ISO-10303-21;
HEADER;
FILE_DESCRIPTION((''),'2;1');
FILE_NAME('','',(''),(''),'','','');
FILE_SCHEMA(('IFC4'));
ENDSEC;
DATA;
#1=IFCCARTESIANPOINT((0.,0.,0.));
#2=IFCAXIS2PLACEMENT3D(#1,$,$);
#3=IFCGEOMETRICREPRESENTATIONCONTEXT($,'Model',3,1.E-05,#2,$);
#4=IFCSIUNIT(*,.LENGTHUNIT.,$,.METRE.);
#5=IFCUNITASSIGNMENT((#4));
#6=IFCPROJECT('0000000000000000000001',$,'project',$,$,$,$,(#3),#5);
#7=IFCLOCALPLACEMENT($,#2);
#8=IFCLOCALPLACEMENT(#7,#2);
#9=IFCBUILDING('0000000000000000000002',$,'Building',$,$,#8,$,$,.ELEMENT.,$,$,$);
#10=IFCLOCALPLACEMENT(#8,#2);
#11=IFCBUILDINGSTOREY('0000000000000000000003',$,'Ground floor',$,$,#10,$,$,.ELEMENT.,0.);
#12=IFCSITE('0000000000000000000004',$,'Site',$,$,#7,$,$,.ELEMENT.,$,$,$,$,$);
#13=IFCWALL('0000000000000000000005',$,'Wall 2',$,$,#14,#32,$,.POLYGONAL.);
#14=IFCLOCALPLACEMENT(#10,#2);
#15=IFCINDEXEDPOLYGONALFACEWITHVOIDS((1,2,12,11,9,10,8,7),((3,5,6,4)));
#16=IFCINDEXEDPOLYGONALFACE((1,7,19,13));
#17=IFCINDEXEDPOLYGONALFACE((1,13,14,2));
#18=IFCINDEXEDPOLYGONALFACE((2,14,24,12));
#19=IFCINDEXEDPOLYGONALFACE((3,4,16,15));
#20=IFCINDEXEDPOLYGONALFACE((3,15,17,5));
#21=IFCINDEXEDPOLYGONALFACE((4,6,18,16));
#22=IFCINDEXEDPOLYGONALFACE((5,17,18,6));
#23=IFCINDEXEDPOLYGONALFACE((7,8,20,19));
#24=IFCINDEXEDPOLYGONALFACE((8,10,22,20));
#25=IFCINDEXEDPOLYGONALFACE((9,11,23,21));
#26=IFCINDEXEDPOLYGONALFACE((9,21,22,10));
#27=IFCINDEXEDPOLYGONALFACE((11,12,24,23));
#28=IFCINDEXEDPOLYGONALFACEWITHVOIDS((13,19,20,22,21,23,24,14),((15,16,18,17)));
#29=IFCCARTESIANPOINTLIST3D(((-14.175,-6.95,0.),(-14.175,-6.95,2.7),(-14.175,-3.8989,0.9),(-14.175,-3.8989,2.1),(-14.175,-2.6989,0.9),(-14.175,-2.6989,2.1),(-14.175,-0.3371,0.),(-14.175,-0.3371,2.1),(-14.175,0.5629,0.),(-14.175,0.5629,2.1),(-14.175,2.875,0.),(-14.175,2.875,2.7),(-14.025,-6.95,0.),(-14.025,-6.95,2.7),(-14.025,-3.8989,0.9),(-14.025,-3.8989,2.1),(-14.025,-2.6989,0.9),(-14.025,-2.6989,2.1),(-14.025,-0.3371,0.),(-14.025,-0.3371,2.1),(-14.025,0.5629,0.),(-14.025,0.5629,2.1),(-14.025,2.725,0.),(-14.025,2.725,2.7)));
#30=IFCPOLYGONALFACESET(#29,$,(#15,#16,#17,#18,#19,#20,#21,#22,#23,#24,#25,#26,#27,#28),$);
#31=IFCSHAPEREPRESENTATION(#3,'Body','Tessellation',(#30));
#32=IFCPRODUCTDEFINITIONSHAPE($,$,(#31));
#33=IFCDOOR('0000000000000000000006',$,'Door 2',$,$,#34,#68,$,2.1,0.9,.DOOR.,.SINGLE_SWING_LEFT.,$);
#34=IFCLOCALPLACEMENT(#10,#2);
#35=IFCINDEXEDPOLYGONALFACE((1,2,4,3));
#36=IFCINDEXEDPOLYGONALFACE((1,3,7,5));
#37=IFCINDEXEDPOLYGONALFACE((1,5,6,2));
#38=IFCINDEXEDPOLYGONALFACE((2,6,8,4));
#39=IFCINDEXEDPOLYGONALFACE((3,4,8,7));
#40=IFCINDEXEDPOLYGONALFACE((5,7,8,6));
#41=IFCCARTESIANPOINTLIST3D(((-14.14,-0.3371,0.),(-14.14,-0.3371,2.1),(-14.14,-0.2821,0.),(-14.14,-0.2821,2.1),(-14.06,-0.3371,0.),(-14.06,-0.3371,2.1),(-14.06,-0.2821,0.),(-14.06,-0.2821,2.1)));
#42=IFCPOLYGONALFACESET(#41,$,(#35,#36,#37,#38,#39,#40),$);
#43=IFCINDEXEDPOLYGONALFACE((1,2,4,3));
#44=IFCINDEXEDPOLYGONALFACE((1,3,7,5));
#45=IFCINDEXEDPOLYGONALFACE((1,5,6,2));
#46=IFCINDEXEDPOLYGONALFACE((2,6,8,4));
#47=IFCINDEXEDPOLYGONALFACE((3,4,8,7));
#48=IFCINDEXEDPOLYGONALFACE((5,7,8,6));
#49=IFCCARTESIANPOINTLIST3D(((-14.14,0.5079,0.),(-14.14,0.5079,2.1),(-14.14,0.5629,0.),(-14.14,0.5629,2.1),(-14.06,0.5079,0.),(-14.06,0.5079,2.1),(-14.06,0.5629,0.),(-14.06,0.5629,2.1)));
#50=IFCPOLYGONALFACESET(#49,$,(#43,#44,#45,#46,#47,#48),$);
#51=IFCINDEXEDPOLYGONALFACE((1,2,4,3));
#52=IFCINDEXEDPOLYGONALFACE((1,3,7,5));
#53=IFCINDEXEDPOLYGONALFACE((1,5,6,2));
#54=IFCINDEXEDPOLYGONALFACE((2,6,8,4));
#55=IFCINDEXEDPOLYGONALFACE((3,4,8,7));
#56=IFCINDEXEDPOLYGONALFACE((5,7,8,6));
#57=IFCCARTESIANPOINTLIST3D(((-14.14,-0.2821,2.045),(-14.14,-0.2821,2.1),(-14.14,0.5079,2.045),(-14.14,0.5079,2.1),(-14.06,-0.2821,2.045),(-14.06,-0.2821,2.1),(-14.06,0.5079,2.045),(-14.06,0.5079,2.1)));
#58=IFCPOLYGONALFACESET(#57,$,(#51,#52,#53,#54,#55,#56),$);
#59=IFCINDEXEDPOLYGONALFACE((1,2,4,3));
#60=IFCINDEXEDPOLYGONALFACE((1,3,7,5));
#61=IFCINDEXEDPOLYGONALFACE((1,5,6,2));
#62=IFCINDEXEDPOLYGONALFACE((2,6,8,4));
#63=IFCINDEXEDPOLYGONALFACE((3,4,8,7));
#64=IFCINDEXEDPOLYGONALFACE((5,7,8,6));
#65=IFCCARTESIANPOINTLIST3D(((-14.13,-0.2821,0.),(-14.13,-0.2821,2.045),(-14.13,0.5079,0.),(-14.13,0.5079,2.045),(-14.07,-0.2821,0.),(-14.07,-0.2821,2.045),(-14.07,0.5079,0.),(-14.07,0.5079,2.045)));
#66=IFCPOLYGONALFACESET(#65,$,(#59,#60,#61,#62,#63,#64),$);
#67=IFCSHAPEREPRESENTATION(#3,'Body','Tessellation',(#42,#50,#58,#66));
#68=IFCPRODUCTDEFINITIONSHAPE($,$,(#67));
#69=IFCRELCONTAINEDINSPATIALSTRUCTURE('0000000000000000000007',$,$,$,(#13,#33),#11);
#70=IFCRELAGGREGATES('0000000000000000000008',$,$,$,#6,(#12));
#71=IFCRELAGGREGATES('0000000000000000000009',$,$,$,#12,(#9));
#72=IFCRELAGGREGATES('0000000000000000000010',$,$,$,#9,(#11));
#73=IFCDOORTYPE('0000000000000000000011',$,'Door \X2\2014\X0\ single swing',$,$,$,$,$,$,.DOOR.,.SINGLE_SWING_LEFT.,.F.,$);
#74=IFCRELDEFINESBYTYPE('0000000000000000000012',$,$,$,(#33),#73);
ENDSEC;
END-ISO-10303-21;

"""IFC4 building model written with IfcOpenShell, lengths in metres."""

from ifc_helpers import new_model, si_unit, frame, frame_2d, origin, origin_with_axes, place, context, project, spatial, polyline, rectangle, outline, extrude, type_object, element, fill, save


model = new_model("IFC4")

# Units and contexts
model_context = context("Model", 3, precision=1e-05, world=origin())
ifc_project = project(units=[si_unit("LENGTHUNIT", "METRE")], contexts=[model_context])

# Site, building, storey
site_placement = place(None, origin())
site = spatial("IfcSite", under=ifc_project, at=site_placement, Name="Site", CompositionType="ELEMENT")
building_placement = place(site_placement, origin())
building = spatial("IfcBuilding", under=site, at=building_placement, Name="Building", CompositionType="ELEMENT")
storey_placement = place(building_placement, origin())
storey = spatial("IfcBuildingStorey", under=building, at=storey_placement, Name="Ground floor", CompositionType="ELEMENT", Elevation=0.0)

# Shared definitions
door_type = type_object("IfcDoorType", Name="Door — single swing", OperationType="SINGLE_SWING_LEFT", ParameterTakesPrecedence=False, PredefinedType="DOOR")

# Wall, openings, door
wall_1_placement = place(storey_placement, origin_with_axes())
wall_1 = element("IfcWall", 1, at=wall_1_placement, inside=storey, Name="Wall 2", PredefinedType="POLYGONAL", context=model_context, shape_type="SweptSolid", body=[
    extrude(outline(polyline([(-14.175, -6.95), (-14.025, -6.95), (-14.025, 2.725), (-14.175, 2.875), (-14.175, -6.95)])), origin(), (0.0, 0.0, 1.0), 2.7),
])
opening_1_placement = place(storey_placement, frame((-14.1, -3.8989, 0.9), z_axis=(0.0, 0.0, 1.0), x_axis=(0.0, 1.0, 0.0)))
element("IfcOpeningElement", 2, at=opening_1_placement, cuts=wall_1, PredefinedType="OPENING", context=model_context, shape_type="SweptSolid", body=[
    extrude(rectangle(XDim=1.2, YDim=0.21, at=frame_2d((0.6, 0.0))), origin(), (0.0, 0.0, 1.0), 1.2),
])
opening_2_placement = place(storey_placement, frame((-14.1, -0.3371, 0.0), z_axis=(0.0, 0.0, 1.0), x_axis=(0.0, 1.0, 0.0)))
opening_2 = element("IfcOpeningElement", 3, at=opening_2_placement, cuts=wall_1, PredefinedType="OPENING", context=model_context, shape_type="SweptSolid", body=[
    extrude(rectangle(XDim=0.9, YDim=0.21, at=frame_2d((0.45, 0.0))), origin(), (0.0, 0.0, 1.0), 2.1),
])
door_1_placement = place(storey_placement, frame((-14.1, -0.3371, 0.0), z_axis=(0.0, 0.0, 1.0), x_axis=(0.0, 1.0, 0.0)))
door_1 = element("IfcDoor", 4, at=door_1_placement, inside=storey, type_object=door_type, Name="Door 2", OperationType="SINGLE_SWING_LEFT", OverallHeight=2.1, OverallWidth=0.9, PredefinedType="DOOR", context=model_context, shape_type="SweptSolid", body=[
    extrude(rectangle(XDim=0.055, YDim=0.08, at=frame_2d((0.0275, 0.0))), origin(), (0.0, 0.0, 1.0), 2.1),
    extrude(rectangle(XDim=0.055, YDim=0.08, at=frame_2d((0.8725, 0.0))), origin(), (0.0, 0.0, 1.0), 2.1),
    extrude(rectangle(XDim=0.79, YDim=0.08, at=frame_2d((0.45, 0.0))), frame((0.0, 0.0, 2.045)), (0.0, 0.0, 1.0), 0.055),
    extrude(rectangle(XDim=0.79, YDim=0.06, at=frame_2d((0.45, 0.0))), origin(), (0.0, 0.0, 1.0), 2.045),
])
fill(opening_2, door_1)

save(model, "model.ifc")
